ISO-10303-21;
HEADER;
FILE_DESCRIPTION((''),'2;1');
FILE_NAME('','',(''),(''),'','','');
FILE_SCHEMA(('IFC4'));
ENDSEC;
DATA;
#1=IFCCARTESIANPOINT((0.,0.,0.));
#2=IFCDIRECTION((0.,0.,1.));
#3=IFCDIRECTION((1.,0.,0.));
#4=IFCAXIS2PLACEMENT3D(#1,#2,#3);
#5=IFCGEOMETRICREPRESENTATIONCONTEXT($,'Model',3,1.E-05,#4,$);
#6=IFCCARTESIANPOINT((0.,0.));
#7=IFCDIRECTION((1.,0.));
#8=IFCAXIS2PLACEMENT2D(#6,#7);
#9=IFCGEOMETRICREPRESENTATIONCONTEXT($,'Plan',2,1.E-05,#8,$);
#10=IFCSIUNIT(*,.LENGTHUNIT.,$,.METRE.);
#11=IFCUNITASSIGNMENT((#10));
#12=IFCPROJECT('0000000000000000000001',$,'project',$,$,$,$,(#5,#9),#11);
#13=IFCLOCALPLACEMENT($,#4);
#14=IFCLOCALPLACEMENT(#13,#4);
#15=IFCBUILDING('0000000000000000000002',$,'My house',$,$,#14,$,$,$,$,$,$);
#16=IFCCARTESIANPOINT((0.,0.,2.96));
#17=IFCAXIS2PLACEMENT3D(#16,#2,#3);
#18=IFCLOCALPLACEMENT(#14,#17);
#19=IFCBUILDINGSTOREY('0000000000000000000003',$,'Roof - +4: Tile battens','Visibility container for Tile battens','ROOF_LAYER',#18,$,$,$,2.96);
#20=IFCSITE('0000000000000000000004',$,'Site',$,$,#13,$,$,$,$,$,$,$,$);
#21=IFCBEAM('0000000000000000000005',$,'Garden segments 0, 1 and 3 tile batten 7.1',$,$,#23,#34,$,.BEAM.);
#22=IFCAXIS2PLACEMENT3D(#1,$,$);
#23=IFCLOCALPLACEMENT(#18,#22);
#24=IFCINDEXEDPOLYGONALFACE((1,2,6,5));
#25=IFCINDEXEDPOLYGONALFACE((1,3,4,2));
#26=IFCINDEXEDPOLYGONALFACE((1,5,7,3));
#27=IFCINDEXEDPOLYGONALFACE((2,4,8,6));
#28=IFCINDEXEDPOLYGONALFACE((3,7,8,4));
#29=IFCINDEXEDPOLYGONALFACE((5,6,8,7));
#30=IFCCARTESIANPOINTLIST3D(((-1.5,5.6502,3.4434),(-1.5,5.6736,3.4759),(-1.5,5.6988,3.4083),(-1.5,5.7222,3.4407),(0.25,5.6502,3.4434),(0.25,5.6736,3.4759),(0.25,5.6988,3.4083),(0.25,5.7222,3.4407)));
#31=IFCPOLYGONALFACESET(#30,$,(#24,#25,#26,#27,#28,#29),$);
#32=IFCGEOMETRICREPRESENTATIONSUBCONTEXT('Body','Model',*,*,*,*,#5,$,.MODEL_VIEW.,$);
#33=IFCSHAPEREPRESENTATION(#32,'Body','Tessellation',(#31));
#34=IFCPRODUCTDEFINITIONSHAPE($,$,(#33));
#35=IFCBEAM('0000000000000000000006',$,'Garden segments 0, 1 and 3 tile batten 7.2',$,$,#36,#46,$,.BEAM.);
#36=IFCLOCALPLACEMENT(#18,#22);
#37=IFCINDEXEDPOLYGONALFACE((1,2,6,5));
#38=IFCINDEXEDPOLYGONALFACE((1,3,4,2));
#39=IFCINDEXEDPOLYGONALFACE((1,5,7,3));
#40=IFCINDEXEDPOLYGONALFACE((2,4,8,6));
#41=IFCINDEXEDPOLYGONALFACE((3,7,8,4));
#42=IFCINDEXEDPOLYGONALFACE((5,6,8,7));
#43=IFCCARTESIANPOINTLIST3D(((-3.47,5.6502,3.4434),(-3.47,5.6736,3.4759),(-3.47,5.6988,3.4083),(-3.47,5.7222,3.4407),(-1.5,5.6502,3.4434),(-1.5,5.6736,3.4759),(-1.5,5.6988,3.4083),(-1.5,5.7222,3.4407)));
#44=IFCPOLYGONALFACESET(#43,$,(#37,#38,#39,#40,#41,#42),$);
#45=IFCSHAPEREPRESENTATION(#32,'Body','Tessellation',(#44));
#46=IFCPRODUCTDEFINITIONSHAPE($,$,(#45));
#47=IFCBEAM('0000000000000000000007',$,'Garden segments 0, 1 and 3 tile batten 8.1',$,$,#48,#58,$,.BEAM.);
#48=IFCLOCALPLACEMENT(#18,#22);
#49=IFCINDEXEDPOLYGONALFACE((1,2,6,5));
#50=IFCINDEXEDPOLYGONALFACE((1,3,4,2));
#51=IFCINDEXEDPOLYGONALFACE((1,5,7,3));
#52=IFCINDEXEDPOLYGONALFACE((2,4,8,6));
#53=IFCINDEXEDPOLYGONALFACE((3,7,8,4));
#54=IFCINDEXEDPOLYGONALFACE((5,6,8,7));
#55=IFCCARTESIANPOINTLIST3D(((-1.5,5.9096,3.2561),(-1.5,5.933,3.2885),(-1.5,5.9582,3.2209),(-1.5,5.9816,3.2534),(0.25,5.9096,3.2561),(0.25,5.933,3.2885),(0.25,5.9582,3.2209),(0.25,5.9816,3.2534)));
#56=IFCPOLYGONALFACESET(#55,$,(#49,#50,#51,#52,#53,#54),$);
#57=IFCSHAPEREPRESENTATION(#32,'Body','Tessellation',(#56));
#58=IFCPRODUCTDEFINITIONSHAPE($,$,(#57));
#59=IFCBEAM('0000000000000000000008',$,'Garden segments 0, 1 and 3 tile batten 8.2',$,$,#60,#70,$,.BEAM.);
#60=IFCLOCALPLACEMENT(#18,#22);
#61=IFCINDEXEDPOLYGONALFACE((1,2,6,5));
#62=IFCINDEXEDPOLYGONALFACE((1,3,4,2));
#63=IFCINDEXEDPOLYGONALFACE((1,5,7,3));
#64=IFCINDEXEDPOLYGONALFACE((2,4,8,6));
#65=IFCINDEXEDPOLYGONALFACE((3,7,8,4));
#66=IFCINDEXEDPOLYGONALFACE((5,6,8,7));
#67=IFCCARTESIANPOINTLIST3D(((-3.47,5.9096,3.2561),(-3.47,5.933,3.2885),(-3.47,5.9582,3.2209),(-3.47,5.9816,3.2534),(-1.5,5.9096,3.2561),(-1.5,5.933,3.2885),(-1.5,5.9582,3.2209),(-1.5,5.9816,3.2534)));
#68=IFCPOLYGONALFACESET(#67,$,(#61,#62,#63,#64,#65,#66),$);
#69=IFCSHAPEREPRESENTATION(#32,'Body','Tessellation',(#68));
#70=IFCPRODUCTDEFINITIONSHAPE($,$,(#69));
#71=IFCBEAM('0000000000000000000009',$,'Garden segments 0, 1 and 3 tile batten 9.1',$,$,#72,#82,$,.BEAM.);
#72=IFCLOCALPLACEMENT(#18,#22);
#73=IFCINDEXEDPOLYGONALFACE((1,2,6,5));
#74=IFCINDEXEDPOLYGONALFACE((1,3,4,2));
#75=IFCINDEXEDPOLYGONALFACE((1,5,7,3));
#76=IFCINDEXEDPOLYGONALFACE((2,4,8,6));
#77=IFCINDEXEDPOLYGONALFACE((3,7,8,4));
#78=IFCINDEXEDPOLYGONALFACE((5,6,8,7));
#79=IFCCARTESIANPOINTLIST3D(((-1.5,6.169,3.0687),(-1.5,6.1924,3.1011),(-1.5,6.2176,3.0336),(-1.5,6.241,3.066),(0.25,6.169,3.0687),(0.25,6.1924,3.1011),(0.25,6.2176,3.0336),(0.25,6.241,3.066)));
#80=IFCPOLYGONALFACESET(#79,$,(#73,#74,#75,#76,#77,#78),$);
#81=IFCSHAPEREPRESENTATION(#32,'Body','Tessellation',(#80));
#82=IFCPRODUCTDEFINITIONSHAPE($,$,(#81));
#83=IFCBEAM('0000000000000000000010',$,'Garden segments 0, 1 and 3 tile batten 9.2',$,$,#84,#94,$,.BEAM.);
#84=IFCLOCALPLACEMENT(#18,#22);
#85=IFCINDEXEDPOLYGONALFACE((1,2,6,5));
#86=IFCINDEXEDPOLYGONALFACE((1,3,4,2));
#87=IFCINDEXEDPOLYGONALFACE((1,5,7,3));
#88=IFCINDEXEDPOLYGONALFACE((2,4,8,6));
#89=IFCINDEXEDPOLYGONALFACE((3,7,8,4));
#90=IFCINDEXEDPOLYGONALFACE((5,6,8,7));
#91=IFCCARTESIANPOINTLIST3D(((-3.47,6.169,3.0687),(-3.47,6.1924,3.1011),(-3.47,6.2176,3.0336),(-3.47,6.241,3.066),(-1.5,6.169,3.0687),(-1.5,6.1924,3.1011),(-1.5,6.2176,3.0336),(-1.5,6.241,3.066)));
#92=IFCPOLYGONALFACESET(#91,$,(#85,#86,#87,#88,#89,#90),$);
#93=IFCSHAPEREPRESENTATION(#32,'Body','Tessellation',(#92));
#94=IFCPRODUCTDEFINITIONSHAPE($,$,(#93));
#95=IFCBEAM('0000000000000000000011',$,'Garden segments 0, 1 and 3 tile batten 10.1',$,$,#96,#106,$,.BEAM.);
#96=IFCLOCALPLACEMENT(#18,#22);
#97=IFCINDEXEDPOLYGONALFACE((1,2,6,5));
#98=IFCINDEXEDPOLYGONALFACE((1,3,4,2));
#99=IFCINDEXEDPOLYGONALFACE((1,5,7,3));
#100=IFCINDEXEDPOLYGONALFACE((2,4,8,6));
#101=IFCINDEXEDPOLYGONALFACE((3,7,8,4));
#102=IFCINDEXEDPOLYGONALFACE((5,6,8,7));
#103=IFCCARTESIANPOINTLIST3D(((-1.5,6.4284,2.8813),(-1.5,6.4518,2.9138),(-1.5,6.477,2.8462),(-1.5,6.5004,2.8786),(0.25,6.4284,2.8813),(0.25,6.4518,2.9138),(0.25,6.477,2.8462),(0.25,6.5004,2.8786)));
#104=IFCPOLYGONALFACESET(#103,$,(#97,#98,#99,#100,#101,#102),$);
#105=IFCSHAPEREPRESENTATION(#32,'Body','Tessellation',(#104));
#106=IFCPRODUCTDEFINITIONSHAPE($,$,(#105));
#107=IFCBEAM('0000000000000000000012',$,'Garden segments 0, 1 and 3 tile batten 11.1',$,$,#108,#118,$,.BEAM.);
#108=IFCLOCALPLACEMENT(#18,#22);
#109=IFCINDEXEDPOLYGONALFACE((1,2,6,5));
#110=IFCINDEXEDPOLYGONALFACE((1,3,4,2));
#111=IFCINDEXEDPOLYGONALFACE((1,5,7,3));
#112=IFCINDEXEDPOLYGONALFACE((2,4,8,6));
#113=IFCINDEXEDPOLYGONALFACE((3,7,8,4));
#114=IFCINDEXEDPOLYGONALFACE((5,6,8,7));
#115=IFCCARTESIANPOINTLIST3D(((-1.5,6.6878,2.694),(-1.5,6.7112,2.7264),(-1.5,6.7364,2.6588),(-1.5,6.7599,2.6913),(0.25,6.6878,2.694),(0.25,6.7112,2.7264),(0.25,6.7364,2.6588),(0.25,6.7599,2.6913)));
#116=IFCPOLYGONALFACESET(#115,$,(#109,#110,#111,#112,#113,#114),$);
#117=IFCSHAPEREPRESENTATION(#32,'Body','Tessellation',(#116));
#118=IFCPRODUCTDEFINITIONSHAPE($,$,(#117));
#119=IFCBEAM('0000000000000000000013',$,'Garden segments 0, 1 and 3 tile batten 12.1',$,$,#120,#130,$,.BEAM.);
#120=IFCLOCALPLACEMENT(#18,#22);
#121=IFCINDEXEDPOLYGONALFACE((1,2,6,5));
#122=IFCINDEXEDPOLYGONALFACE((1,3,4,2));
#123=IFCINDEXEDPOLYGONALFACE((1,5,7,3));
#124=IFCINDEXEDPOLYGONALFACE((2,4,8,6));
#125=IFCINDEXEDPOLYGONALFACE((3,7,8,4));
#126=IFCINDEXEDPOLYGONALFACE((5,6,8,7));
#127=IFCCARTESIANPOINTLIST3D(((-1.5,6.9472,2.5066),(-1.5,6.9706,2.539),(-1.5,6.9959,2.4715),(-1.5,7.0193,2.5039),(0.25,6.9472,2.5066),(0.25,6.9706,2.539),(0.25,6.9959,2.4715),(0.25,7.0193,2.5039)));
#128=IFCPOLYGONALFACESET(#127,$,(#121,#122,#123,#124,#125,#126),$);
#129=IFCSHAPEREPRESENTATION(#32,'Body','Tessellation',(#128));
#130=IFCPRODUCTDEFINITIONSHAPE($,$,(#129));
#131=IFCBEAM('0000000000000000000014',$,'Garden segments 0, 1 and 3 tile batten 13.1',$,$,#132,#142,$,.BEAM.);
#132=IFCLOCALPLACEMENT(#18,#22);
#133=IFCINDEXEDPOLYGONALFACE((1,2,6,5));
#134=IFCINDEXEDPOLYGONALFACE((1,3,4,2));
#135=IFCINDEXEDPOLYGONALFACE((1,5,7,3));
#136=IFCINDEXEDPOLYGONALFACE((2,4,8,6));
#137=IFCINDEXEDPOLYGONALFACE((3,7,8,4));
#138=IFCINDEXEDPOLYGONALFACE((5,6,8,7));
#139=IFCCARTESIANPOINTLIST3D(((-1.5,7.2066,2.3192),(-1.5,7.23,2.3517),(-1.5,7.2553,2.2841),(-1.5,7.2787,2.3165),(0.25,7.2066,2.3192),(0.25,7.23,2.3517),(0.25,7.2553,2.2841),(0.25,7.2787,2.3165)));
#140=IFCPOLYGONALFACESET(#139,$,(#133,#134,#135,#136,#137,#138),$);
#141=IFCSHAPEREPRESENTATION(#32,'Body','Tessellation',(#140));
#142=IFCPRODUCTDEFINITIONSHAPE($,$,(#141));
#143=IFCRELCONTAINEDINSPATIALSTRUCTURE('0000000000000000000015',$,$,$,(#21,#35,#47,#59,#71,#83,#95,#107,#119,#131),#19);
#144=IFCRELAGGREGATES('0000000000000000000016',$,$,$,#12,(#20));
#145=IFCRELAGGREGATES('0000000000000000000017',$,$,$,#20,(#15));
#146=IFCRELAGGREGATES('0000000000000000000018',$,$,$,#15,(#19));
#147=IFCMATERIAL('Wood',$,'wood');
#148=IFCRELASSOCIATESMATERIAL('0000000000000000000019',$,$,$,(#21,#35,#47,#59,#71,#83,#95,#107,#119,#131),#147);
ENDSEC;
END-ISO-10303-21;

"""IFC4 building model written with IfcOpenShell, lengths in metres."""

from ifc_helpers import new_model, si_unit, frame, origin_with_axes, origin_2d_with_axis, place, context, subcontext, project, spatial, rectangle, extrude, clip, halfspace, source, transform, mapped, material, element, save


model = new_model("IFC4")

# Units and contexts
model_context = context("Model", 3, precision=1e-05, world=origin_with_axes())
plan_context = context("Plan", 2, precision=1e-05, world=origin_2d_with_axis())
body_context = subcontext(model_context, "Body", "Model", "MODEL_VIEW")
ifc_project = project(units=[si_unit("LENGTHUNIT", "METRE")], contexts=[model_context, plan_context])

# Site, building, storey
site_placement = place(None, origin_with_axes())
site = spatial("IfcSite", under=ifc_project, at=site_placement, Name="Site")
building_placement = place(site_placement, origin_with_axes())
building = spatial("IfcBuilding", under=site, at=building_placement, Name="My house")
storey_placement = place(building_placement, frame((0.0, 0.0, 2.96), z_axis=(0.0, 0.0, 1.0), x_axis=(1.0, 0.0, 0.0)))
storey = spatial("IfcBuildingStorey", under=building, at=storey_placement, Name="Roof - +4: Tile battens", Description="Visibility container for Tile battens", ObjectType="ROOF_LAYER", Elevation=2.96)

# Beams
ifc_material = material(Name="Wood", Category="wood")
shared_shape_1 = source(origin_with_axes(), body_context, "Body", "Clipping", [
    clip(clip(extrude(rectangle(XDim=0.06, YDim=0.04), frame((0.0, 0.0, 0.0), z_axis=(1.0, 0.0, 0.0), x_axis=(0.0, 1.0, 0.0)), (0.0, 0.0, 1.0), 1.75), halfspace(frame((0.25, 2.3816, -6.1772), z_axis=(0.0, -0.810664, -0.585512), x_axis=(-1.0, 0.0, 0.0)), False)), halfspace(frame((0.25, 6.2322, -3.396), z_axis=(0.0, 0.810664, 0.585512), x_axis=(1.0, 0.0, 0.0)), False)),
])
beam_1_placement = place(storey_placement, frame((0.25, 5.6862, 3.4421), z_axis=(0.0, 0.585512, 0.810664), x_axis=(1.0, 0.0, 0.0)))
element("IfcBeam", 1, at=beam_1_placement, inside=storey, material=ifc_material, Name="Garden segments 0, 1 and 3 tile batten 7.1", PredefinedType="BEAM", context=body_context, shape_type="MappedRepresentation", body=[
    mapped(shared_shape_1, transform((0.0, 0.0, 0.0), x_axis=(-1.0, 0.0, 0.0), y_axis=(0.0, 1.0, 0.0), z_axis=(0.0, 0.0, 1.0), scale=1.0)),
])
shared_shape_2 = source(origin_with_axes(), body_context, "Body", "Clipping", [
    clip(clip(extrude(rectangle(XDim=0.06, YDim=0.04), frame((0.0, 0.0, 0.0), z_axis=(1.0, 0.0, 0.0), x_axis=(0.0, 1.0, 0.0)), (0.0, 0.0, 1.0), 1.97), halfspace(frame((-1.5, 2.3816, -6.1772), z_axis=(0.0, -0.810664, -0.585512), x_axis=(-1.0, 0.0, 0.0)), False)), halfspace(frame((-1.5, 6.2322, -3.396), z_axis=(0.0, 0.810664, 0.585512), x_axis=(1.0, 0.0, 0.0)), False)),
])
beam_2_placement = place(storey_placement, frame((-1.5, 5.6862, 3.4421), z_axis=(0.0, 0.585512, 0.810664), x_axis=(1.0, 0.0, 0.0)))
element("IfcBeam", 2, at=beam_2_placement, inside=storey, material=ifc_material, Name="Garden segments 0, 1 and 3 tile batten 7.2", PredefinedType="BEAM", context=body_context, shape_type="MappedRepresentation", body=[
    mapped(shared_shape_2, transform((0.0, 0.0, 0.0), x_axis=(-1.0, 0.0, 0.0), y_axis=(0.0, 1.0, 0.0), z_axis=(0.0, 0.0, 1.0), scale=1.0)),
])
shared_shape_3 = source(origin_with_axes(), body_context, "Body", "Clipping", [
    clip(clip(extrude(rectangle(XDim=0.06, YDim=0.04), frame((0.0, 0.0, 0.0), z_axis=(1.0, 0.0, 0.0), x_axis=(0.0, 1.0, 0.0)), (0.0, 0.0, 1.0), 1.75), halfspace(frame((0.25, 2.0616, -6.1772), z_axis=(0.0, -0.810664, -0.585512), x_axis=(-1.0, 0.0, 0.0)), False)), halfspace(frame((0.25, 5.9122, -3.396), z_axis=(0.0, 0.810664, 0.585512), x_axis=(1.0, 0.0, 0.0)), False)),
])
beam_3_placement = place(storey_placement, frame((0.25, 5.9456, 3.2547), z_axis=(0.0, 0.585512, 0.810664), x_axis=(1.0, 0.0, 0.0)))
element("IfcBeam", 3, at=beam_3_placement, inside=storey, material=ifc_material, Name="Garden segments 0, 1 and 3 tile batten 8.1", PredefinedType="BEAM", context=body_context, shape_type="MappedRepresentation", body=[
    mapped(shared_shape_3, transform((0.0, 0.0, 0.0), x_axis=(-1.0, 0.0, 0.0), y_axis=(0.0, 1.0, 0.0), z_axis=(0.0, 0.0, 1.0), scale=1.0)),
])
shared_shape_4 = source(origin_with_axes(), body_context, "Body", "Clipping", [
    clip(clip(extrude(rectangle(XDim=0.06, YDim=0.04), frame((0.0, 0.0, 0.0), z_axis=(1.0, 0.0, 0.0), x_axis=(0.0, 1.0, 0.0)), (0.0, 0.0, 1.0), 1.97), halfspace(frame((-1.5, 2.0616, -6.1772), z_axis=(0.0, -0.810664, -0.585512), x_axis=(-1.0, 0.0, 0.0)), False)), halfspace(frame((-1.5, 5.9122, -3.396), z_axis=(0.0, 0.810664, 0.585512), x_axis=(1.0, 0.0, 0.0)), False)),
])
beam_4_placement = place(storey_placement, frame((-1.5, 5.9456, 3.2547), z_axis=(0.0, 0.585512, 0.810664), x_axis=(1.0, 0.0, 0.0)))
element("IfcBeam", 4, at=beam_4_placement, inside=storey, material=ifc_material, Name="Garden segments 0, 1 and 3 tile batten 8.2", PredefinedType="BEAM", context=body_context, shape_type="MappedRepresentation", body=[
    mapped(shared_shape_4, transform((0.0, 0.0, 0.0), x_axis=(-1.0, 0.0, 0.0), y_axis=(0.0, 1.0, 0.0), z_axis=(0.0, 0.0, 1.0), scale=1.0)),
])
shared_shape_5 = source(origin_with_axes(), body_context, "Body", "Clipping", [
    clip(clip(extrude(rectangle(XDim=0.06, YDim=0.04), frame((0.0, 0.0, 0.0), z_axis=(1.0, 0.0, 0.0), x_axis=(0.0, 1.0, 0.0)), (0.0, 0.0, 1.0), 1.75), halfspace(frame((0.25, 1.7416, -6.1772), z_axis=(0.0, -0.810664, -0.585512), x_axis=(-1.0, 0.0, 0.0)), False)), halfspace(frame((0.25, 5.5922, -3.396), z_axis=(0.0, 0.810664, 0.585512), x_axis=(1.0, 0.0, 0.0)), False)),
])
beam_5_placement = place(storey_placement, frame((0.25, 6.205, 3.0673), z_axis=(0.0, 0.585512, 0.810664), x_axis=(1.0, 0.0, 0.0)))
element("IfcBeam", 5, at=beam_5_placement, inside=storey, material=ifc_material, Name="Garden segments 0, 1 and 3 tile batten 9.1", PredefinedType="BEAM", context=body_context, shape_type="MappedRepresentation", body=[
    mapped(shared_shape_5, transform((0.0, 0.0, 0.0), x_axis=(-1.0, 0.0, 0.0), y_axis=(0.0, 1.0, 0.0), z_axis=(0.0, 0.0, 1.0), scale=1.0)),
])
shared_shape_6 = source(origin_with_axes(), body_context, "Body", "Clipping", [
    clip(clip(extrude(rectangle(XDim=0.06, YDim=0.04), frame((0.0, 0.0, 0.0), z_axis=(1.0, 0.0, 0.0), x_axis=(0.0, 1.0, 0.0)), (0.0, 0.0, 1.0), 1.97), halfspace(frame((-1.5, 1.7416, -6.1772), z_axis=(0.0, -0.810664, -0.585512), x_axis=(-1.0, 0.0, 0.0)), False)), halfspace(frame((-1.5, 5.5922, -3.396), z_axis=(0.0, 0.810664, 0.585512), x_axis=(1.0, 0.0, 0.0)), False)),
])
beam_6_placement = place(storey_placement, frame((-1.5, 6.205, 3.0673), z_axis=(0.0, 0.585512, 0.810664), x_axis=(1.0, 0.0, 0.0)))
element("IfcBeam", 6, at=beam_6_placement, inside=storey, material=ifc_material, Name="Garden segments 0, 1 and 3 tile batten 9.2", PredefinedType="BEAM", context=body_context, shape_type="MappedRepresentation", body=[
    mapped(shared_shape_6, transform((0.0, 0.0, 0.0), x_axis=(-1.0, 0.0, 0.0), y_axis=(0.0, 1.0, 0.0), z_axis=(0.0, 0.0, 1.0), scale=1.0)),
])
shared_shape_7 = source(origin_with_axes(), body_context, "Body", "Clipping", [
    clip(clip(extrude(rectangle(XDim=0.06, YDim=0.04), frame((0.0, 0.0, 0.0), z_axis=(1.0, 0.0, 0.0), x_axis=(0.0, 1.0, 0.0)), (0.0, 0.0, 1.0), 1.75), halfspace(frame((0.25, 1.4216, -6.1772), z_axis=(0.0, -0.810664, -0.585512), x_axis=(-1.0, 0.0, 0.0)), False)), halfspace(frame((0.25, 5.2722, -3.396), z_axis=(0.0, 0.810664, 0.585512), x_axis=(1.0, 0.0, 0.0)), False)),
])
beam_7_placement = place(storey_placement, frame((0.25, 6.4644, 2.88), z_axis=(0.0, 0.585512, 0.810664), x_axis=(1.0, 0.0, 0.0)))
element("IfcBeam", 7, at=beam_7_placement, inside=storey, material=ifc_material, Name="Garden segments 0, 1 and 3 tile batten 10.1", PredefinedType="BEAM", context=body_context, shape_type="MappedRepresentation", body=[
    mapped(shared_shape_7, transform((0.0, 0.0, 0.0), x_axis=(-1.0, 0.0, 0.0), y_axis=(0.0, 1.0, 0.0), z_axis=(0.0, 0.0, 1.0), scale=1.0)),
])

# Beam
shared_shape_8 = source(origin_with_axes(), body_context, "Body", "Clipping", [
    clip(clip(extrude(rectangle(XDim=0.06, YDim=0.04), frame((0.0, 0.0, 0.0), z_axis=(1.0, 0.0, 0.0), x_axis=(0.0, 1.0, 0.0)), (0.0, 0.0, 1.0), 1.75), halfspace(frame((0.25, 1.1016, -6.1772), z_axis=(0.0, -0.810664, -0.585512), x_axis=(-1.0, 0.0, 0.0)), False)), halfspace(frame((0.25, 4.9522, -3.396), z_axis=(0.0, 0.810664, 0.585512), x_axis=(1.0, 0.0, 0.0)), False)),
])
beam_8_placement = place(storey_placement, frame((0.25, 6.7238, 2.6926), z_axis=(0.0, 0.585512, 0.810664), x_axis=(1.0, 0.0, 0.0)))
element("IfcBeam", 8, at=beam_8_placement, inside=storey, material=ifc_material, Name="Garden segments 0, 1 and 3 tile batten 11.1", PredefinedType="BEAM", context=body_context, shape_type="MappedRepresentation", body=[
    mapped(shared_shape_8, transform((0.0, 0.0, 0.0), x_axis=(-1.0, 0.0, 0.0), y_axis=(0.0, 1.0, 0.0), z_axis=(0.0, 0.0, 1.0), scale=1.0)),
])

# Beam
shared_shape_9 = source(origin_with_axes(), body_context, "Body", "Clipping", [
    clip(clip(extrude(rectangle(XDim=0.06, YDim=0.04), frame((0.0, 0.0, 0.0), z_axis=(1.0, 0.0, 0.0), x_axis=(0.0, 1.0, 0.0)), (0.0, 0.0, 1.0), 1.75), halfspace(frame((0.25, 0.7816, -6.1772), z_axis=(0.0, -0.810664, -0.585512), x_axis=(-1.0, 0.0, 0.0)), False)), halfspace(frame((0.25, 4.6322, -3.396), z_axis=(0.0, 0.810664, 0.585512), x_axis=(1.0, 0.0, 0.0)), False)),
])
beam_9_placement = place(storey_placement, frame((0.25, 6.9832, 2.5053), z_axis=(0.0, 0.585512, 0.810664), x_axis=(1.0, 0.0, 0.0)))
element("IfcBeam", 9, at=beam_9_placement, inside=storey, material=ifc_material, Name="Garden segments 0, 1 and 3 tile batten 12.1", PredefinedType="BEAM", context=body_context, shape_type="MappedRepresentation", body=[
    mapped(shared_shape_9, transform((0.0, 0.0, 0.0), x_axis=(-1.0, 0.0, 0.0), y_axis=(0.0, 1.0, 0.0), z_axis=(0.0, 0.0, 1.0), scale=1.0)),
])

# Beam
shared_shape_10 = source(origin_with_axes(), body_context, "Body", "Clipping", [
    clip(clip(extrude(rectangle(XDim=0.06, YDim=0.04), frame((0.0, 0.0, 0.0), z_axis=(1.0, 0.0, 0.0), x_axis=(0.0, 1.0, 0.0)), (0.0, 0.0, 1.0), 1.75), halfspace(frame((0.25, 0.4616, -6.1772), z_axis=(0.0, -0.810664, -0.585512), x_axis=(-1.0, 0.0, 0.0)), False)), halfspace(frame((0.25, 4.3122, -3.396), z_axis=(0.0, 0.810664, 0.585512), x_axis=(1.0, 0.0, 0.0)), False)),
])
beam_10_placement = place(storey_placement, frame((0.25, 7.2427, 2.3179), z_axis=(0.0, 0.585512, 0.810664), x_axis=(1.0, 0.0, 0.0)))
element("IfcBeam", 10, at=beam_10_placement, inside=storey, material=ifc_material, Name="Garden segments 0, 1 and 3 tile batten 13.1", PredefinedType="BEAM", context=body_context, shape_type="MappedRepresentation", body=[
    mapped(shared_shape_10, transform((0.0, 0.0, 0.0), x_axis=(-1.0, 0.0, 0.0), y_axis=(0.0, 1.0, 0.0), z_axis=(0.0, 0.0, 1.0), scale=1.0)),
])

save(model, "model.ifc")
